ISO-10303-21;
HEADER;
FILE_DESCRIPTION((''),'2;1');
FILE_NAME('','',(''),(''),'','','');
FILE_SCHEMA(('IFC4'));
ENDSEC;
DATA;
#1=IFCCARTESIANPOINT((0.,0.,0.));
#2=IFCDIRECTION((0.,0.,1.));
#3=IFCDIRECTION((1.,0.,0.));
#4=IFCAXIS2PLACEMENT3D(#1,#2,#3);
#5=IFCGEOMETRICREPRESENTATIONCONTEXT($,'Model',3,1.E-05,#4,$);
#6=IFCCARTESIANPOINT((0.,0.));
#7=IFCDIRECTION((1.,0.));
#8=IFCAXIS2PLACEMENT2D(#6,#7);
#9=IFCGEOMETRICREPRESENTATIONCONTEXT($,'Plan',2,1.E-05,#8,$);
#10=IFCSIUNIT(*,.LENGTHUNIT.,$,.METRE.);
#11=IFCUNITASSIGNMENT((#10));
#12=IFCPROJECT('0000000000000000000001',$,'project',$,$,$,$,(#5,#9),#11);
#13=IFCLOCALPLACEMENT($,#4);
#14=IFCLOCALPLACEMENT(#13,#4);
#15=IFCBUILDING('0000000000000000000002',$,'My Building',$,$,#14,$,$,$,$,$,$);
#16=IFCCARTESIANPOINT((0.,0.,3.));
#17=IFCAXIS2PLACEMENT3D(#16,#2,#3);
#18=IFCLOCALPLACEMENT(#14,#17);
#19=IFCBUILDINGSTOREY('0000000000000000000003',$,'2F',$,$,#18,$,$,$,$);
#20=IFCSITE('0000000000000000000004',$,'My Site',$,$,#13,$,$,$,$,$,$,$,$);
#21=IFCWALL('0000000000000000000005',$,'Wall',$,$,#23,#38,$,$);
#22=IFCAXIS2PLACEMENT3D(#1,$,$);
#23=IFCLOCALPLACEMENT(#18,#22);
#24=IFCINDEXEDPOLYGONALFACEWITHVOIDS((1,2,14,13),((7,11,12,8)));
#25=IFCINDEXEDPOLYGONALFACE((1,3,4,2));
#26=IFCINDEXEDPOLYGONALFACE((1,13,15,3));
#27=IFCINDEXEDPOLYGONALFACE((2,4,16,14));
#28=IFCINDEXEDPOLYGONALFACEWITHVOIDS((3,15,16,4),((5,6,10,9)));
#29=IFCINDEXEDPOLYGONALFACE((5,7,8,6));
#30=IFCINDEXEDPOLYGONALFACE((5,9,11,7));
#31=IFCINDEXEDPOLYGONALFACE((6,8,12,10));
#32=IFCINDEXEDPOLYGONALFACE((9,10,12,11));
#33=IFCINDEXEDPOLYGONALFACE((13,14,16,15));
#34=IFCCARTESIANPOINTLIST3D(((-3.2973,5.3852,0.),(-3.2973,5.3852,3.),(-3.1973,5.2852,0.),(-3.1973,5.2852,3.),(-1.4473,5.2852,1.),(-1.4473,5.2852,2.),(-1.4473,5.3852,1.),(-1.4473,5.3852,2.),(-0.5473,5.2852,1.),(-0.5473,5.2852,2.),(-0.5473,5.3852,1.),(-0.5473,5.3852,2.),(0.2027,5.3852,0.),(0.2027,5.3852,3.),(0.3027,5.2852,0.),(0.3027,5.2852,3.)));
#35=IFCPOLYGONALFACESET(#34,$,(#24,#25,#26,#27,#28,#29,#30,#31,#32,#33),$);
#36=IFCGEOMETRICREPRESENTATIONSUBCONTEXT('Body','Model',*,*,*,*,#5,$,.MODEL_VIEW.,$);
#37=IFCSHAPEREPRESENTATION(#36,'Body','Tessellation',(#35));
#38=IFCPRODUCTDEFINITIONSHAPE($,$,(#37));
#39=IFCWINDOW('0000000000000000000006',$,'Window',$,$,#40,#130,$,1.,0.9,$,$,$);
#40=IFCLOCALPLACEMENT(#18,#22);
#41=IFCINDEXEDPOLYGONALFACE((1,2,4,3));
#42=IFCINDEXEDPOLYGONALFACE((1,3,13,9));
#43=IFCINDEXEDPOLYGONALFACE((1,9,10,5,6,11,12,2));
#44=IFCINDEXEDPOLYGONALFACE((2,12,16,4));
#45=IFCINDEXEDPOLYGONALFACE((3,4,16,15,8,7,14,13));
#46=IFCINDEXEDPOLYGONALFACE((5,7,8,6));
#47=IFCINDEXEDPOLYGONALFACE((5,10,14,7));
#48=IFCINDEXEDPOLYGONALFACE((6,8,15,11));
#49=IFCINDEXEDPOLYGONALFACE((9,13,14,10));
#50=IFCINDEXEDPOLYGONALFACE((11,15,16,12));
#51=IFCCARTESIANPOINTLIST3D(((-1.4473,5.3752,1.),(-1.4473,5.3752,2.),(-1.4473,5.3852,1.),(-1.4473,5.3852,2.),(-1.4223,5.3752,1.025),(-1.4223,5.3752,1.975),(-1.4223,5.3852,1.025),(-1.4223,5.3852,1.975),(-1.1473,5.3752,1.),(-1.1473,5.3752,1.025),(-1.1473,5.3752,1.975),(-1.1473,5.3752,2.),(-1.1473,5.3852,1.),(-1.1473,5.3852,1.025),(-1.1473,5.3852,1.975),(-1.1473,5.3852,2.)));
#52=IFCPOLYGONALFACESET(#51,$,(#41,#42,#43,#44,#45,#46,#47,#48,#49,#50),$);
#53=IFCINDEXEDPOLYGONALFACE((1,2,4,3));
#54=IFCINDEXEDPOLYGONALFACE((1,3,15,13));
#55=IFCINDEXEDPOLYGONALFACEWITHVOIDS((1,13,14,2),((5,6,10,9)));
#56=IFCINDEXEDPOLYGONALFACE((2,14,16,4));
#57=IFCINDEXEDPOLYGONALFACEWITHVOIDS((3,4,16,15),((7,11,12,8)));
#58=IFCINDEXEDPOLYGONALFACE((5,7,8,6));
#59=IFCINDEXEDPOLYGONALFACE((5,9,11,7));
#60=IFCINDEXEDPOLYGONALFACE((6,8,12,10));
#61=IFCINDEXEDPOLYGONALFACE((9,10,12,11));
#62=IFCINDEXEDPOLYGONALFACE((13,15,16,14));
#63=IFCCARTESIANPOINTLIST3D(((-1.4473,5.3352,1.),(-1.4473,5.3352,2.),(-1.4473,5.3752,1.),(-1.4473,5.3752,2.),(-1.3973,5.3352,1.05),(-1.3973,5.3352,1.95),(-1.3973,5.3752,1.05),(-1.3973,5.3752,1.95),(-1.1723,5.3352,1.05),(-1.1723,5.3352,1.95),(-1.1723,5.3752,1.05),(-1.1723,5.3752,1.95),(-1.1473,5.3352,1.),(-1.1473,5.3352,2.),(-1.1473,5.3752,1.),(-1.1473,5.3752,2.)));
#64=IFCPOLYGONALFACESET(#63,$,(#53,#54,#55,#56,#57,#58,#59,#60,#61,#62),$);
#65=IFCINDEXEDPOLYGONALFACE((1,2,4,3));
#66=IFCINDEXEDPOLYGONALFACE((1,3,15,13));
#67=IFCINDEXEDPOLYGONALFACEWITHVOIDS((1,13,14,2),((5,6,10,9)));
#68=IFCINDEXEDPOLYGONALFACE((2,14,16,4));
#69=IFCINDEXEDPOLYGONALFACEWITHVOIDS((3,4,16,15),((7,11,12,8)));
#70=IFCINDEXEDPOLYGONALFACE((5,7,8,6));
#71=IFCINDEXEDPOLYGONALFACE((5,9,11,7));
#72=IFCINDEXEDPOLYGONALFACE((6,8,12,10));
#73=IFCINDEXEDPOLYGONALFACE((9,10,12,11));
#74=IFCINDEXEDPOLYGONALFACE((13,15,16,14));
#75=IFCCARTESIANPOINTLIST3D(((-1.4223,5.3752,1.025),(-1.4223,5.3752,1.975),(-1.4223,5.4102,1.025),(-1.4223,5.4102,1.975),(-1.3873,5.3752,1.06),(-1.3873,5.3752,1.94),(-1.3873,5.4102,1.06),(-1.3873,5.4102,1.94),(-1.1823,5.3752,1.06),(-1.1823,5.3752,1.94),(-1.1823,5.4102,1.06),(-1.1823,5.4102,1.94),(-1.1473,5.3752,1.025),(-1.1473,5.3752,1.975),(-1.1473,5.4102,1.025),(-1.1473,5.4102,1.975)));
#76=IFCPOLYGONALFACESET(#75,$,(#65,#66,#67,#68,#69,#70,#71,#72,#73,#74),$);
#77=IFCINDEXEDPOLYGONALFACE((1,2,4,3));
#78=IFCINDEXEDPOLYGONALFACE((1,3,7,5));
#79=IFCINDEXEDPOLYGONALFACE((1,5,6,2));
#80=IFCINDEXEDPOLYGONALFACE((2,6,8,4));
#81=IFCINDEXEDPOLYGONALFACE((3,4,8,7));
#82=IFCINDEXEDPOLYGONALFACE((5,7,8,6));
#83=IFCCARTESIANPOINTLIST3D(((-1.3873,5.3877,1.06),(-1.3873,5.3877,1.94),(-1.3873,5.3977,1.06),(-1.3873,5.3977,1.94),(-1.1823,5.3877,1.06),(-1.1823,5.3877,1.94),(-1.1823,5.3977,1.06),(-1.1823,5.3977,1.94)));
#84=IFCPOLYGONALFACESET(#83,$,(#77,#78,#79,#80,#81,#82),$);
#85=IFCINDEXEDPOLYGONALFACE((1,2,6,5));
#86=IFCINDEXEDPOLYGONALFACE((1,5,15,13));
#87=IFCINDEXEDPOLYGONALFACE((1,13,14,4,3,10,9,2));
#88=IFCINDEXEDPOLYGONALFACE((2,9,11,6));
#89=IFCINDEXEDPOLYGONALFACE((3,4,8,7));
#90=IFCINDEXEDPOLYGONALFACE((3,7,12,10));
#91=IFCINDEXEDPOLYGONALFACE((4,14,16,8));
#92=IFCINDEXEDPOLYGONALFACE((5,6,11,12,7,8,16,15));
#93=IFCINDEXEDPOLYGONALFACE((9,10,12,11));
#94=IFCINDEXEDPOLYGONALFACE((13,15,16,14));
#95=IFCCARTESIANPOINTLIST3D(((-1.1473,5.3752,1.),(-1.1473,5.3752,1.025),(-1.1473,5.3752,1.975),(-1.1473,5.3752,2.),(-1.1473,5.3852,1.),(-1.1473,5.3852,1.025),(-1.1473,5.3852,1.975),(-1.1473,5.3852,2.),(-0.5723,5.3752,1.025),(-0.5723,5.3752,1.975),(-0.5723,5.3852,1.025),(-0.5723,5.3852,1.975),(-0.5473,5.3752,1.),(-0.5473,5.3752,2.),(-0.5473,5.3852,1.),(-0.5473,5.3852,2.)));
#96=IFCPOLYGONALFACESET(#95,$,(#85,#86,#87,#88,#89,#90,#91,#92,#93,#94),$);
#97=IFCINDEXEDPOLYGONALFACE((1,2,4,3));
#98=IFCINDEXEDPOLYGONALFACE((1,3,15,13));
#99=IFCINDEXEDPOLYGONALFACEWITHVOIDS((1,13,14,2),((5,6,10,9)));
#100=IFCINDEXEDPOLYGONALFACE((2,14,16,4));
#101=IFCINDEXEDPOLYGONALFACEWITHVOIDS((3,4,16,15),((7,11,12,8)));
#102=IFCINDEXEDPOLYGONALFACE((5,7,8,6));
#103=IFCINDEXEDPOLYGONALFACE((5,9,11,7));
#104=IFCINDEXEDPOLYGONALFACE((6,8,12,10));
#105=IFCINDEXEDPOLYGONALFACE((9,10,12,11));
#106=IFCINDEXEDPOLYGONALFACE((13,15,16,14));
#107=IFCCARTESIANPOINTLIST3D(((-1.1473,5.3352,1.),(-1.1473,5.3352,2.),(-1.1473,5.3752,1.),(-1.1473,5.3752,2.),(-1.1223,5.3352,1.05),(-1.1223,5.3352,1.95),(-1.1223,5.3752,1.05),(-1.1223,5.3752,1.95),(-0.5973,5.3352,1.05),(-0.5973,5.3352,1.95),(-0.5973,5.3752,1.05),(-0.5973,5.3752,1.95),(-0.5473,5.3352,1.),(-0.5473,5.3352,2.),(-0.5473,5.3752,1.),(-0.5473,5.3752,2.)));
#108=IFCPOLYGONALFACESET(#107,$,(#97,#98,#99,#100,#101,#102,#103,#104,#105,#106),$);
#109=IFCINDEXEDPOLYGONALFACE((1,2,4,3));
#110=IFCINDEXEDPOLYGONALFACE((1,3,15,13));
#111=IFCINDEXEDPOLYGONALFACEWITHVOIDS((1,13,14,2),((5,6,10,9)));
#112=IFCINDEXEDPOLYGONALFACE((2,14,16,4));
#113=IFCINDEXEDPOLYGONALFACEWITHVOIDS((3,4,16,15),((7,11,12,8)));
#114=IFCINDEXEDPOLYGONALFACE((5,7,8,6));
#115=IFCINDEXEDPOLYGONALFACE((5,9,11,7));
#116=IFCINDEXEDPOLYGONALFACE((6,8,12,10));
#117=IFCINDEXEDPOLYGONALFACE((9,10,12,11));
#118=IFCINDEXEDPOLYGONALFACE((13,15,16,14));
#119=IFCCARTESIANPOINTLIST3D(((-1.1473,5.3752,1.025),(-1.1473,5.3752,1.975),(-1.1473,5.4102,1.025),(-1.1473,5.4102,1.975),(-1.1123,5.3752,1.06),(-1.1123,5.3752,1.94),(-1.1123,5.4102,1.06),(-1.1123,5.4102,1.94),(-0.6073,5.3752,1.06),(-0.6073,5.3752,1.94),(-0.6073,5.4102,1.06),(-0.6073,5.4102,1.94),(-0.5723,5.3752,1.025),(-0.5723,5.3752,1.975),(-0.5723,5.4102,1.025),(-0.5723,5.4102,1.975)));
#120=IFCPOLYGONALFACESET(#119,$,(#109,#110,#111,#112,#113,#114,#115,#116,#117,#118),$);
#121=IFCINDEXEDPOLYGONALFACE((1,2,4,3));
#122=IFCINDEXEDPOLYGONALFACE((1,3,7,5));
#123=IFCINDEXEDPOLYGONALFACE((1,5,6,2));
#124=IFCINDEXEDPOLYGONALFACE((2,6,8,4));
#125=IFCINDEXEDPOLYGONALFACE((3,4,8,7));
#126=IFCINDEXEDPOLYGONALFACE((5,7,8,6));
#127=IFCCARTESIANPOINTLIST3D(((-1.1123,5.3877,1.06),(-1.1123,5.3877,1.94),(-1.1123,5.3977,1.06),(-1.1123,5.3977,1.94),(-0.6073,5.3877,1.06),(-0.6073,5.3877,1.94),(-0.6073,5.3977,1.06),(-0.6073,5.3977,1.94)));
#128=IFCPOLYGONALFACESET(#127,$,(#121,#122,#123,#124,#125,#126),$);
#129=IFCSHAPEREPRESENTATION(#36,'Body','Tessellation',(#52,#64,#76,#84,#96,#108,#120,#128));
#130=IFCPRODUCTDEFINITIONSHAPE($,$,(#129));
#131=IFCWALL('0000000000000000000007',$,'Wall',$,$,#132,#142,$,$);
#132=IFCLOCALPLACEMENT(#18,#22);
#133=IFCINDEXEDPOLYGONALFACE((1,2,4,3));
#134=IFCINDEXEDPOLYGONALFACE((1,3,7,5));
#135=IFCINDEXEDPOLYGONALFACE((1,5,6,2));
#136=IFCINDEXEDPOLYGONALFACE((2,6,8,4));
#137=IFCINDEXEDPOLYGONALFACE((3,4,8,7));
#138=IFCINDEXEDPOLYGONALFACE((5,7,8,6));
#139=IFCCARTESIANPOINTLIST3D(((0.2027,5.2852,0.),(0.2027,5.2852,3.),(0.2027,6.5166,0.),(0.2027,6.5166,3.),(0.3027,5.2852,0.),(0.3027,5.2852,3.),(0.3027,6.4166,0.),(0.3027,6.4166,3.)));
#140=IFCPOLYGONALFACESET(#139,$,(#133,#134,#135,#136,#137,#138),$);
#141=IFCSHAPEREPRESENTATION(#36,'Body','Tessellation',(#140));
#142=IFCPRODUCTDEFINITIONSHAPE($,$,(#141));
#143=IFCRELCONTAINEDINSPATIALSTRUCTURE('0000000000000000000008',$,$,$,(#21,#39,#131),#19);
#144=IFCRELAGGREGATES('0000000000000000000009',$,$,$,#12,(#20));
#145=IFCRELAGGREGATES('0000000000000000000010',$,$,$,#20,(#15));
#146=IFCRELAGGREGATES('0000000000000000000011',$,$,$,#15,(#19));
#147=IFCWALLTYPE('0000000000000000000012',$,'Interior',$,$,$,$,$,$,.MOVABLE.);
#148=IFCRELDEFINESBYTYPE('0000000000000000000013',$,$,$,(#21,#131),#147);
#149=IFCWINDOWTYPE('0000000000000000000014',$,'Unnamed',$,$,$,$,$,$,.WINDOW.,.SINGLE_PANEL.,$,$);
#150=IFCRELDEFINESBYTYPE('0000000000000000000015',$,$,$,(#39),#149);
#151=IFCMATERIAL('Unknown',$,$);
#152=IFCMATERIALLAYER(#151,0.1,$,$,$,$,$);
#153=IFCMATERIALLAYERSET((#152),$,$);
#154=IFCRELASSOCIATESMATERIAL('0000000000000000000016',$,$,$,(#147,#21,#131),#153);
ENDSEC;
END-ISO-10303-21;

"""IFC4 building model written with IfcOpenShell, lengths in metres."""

from ifc_helpers import new_model, entity, si_unit, frame, origin_with_axes, origin_2d_with_axis, place, context, subcontext, project, spatial, line, indexed_curve, outline, extrude, shape, source, transform, mapped, material, layer, layer_set, layer_usage, type_object, type_shapes, element, fill, save


model = new_model("IFC4")

# Units and contexts
model_context = context("Model", 3, precision=1e-05, world=origin_with_axes())
plan_context = context("Plan", 2, precision=1e-05, world=origin_2d_with_axis())
body_context_1 = subcontext(model_context, "Body", "Model", "MODEL_VIEW")
body_context_2 = subcontext(plan_context, "Body", "Plan", "PLAN_VIEW")
ifc_project = project(units=[si_unit("LENGTHUNIT", "METRE")], contexts=[model_context, plan_context])

# Site, building, storey
site_placement = place(None, origin_with_axes())
site = spatial("IfcSite", under=ifc_project, at=site_placement, Name="My Site")
building_placement = place(site_placement, origin_with_axes())
building = spatial("IfcBuilding", under=site, at=building_placement, Name="My Building")
storey_placement = place(building_placement, frame((0.0, 0.0, 3.0), z_axis=(0.0, 0.0, 1.0), x_axis=(1.0, 0.0, 0.0)))
storey = spatial("IfcBuildingStorey", under=building, at=storey_placement, Name="2F")

# Shared definitions
ifc_material = material(Name="Unknown")

# Wall, opening, window
ifc_layer_1 = layer(ifc_material, 0.1)
ifc_layer_set_1 = layer_set([ifc_layer_1])
ifc_layer_usage_1 = layer_usage(ifc_layer_set_1, "AXIS2", "POSITIVE", 0.0)
wall_type = type_object("IfcWallType", Name="Interior", PredefinedType="MOVABLE", material=ifc_layer_set_1)
wall_1_placement = place(storey_placement, frame((0.2027, 5.3852, 0.0), z_axis=(0.0, 0.0, 1.0), x_axis=(-1.0, 0.0, 0.0)))
wall_1 = element("IfcWall", 1, at=wall_1_placement, inside=storey, type_object=wall_type, material=ifc_layer_usage_1, Name="Wall", context=body_context_1, shape_type="SweptSolid", body=[
    extrude(outline(indexed_curve([(0.0, 0.0), (-0.1, 0.1), (3.4, 0.1), (3.5, 0.0)], segments=[line(1, 2, 3, 4, 1)])), origin_with_axes(), (0.0, 0.0, 1.0), 3.0),
])
shared_shape_1 = source(origin_with_axes(), body_context_1, "Body", "SweptSolid", [
    extrude(outline(indexed_curve([(0.0, 0.0), (0.9, 0.0), (0.9, 1.0), (0.0, 1.0)], segments=[line(1, 2, 3, 4, 1)])), frame((0.0, -0.6, 0.0), z_axis=(0.0, -1.0, 0.0), x_axis=(1.0, 0.0, 0.0)), (0.0, 0.0, -1.0), 1.2),
])
opening_1_placement = place(wall_1_placement, frame((1.65, 0.1, 1.0), z_axis=(0.0, 0.0, 1.0), x_axis=(-1.0, 0.0, 0.0)))
opening_1 = element("IfcOpeningElement", 2, at=opening_1_placement, cuts=wall_1, PredefinedType="OPENING", context=body_context_1, shape_type="MappedRepresentation", body=[
    mapped(shared_shape_1, transform((0.0, 0.0, 0.0), x_axis=(1.0, 0.0, 0.0), y_axis=(0.0, 1.0, 0.0), z_axis=(0.0, 0.0, 1.0), scale=1.0)),
])
window_type = type_object("IfcWindowType", Name="Unnamed", PartitioningType="SINGLE_PANEL", PredefinedType="WINDOW")
shared_shape_2 = source(origin_with_axes(), body_context_1, "Body", "SweptSolid", [
    extrude(outline(indexed_curve([(0.3, 0.0), (0.0, 0.0), (0.0, 1.0), (0.3, 1.0), (0.3, 0.975), (0.025, 0.975), (0.025, 0.025), (0.3, 0.025)], segments=[line(1, 2, 3, 4, 5, 6, 7, 8, 1)])), frame((0.0, 0.09, 0.0), z_axis=(0.0, -1.0, 0.0), x_axis=(1.0, 0.0, 0.0)), (0.0, 0.0, -1.0), 0.01),
    extrude(outline(indexed_curve([(0.0, 0.0), (0.3, 0.0), (0.3, 1.0), (0.0, 1.0)], segments=[line(1, 2, 3, 4, 1)]), holes=[indexed_curve([(0.05, 0.05), (0.275, 0.05), (0.275, 0.95), (0.05, 0.95)], segments=[line(1, 2, 3, 4, 1)])]), frame((0.0, 0.05, 0.0), z_axis=(0.0, -1.0, 0.0), x_axis=(1.0, 0.0, 0.0)), (0.0, 0.0, -1.0), 0.04),
    extrude(outline(indexed_curve([(0.0, 0.0), (0.275, 0.0), (0.275, 0.95), (0.0, 0.95)], segments=[line(1, 2, 3, 4, 1)]), holes=[indexed_curve([(0.035, 0.035), (0.24, 0.035), (0.24, 0.915), (0.035, 0.915)], segments=[line(1, 2, 3, 4, 1)])]), frame((0.025, 0.09, 0.025), z_axis=(0.0, -1.0, 0.0), x_axis=(1.0, 0.0, 0.0)), (0.0, 0.0, -1.0), 0.035),
    extrude(outline(indexed_curve([(0.035, 0.035), (0.24, 0.035), (0.24, 0.915), (0.035, 0.915)], segments=[line(1, 2, 3, 4, 1)])), frame((0.025, 0.1025, 0.025), z_axis=(0.0, -1.0, 0.0), x_axis=(1.0, 0.0, 0.0)), (0.0, 0.0, -1.0), 0.01),
    extrude(outline(indexed_curve([(0.0, 1.0), (0.6, 1.0), (0.6, 0.0), (0.0, 0.0), (0.0, 0.025), (0.575, 0.025), (0.575, 0.975), (0.0, 0.975)], segments=[line(1, 2, 3, 4, 5, 6, 7, 8, 1)])), frame((0.3, 0.09, 0.0), z_axis=(0.0, -1.0, 0.0), x_axis=(1.0, 0.0, 0.0)), (0.0, 0.0, -1.0), 0.01),
    extrude(outline(indexed_curve([(0.0, 0.0), (0.6, 0.0), (0.6, 1.0), (0.0, 1.0)], segments=[line(1, 2, 3, 4, 1)]), holes=[indexed_curve([(0.025, 0.05), (0.55, 0.05), (0.55, 0.95), (0.025, 0.95)], segments=[line(1, 2, 3, 4, 1)])]), frame((0.3, 0.05, 0.0), z_axis=(0.0, -1.0, 0.0), x_axis=(1.0, 0.0, 0.0)), (0.0, 0.0, -1.0), 0.04),
    extrude(outline(indexed_curve([(0.0, 0.0), (0.575, 0.0), (0.575, 0.95), (0.0, 0.95)], segments=[line(1, 2, 3, 4, 1)]), holes=[indexed_curve([(0.035, 0.035), (0.54, 0.035), (0.54, 0.915), (0.035, 0.915)], segments=[line(1, 2, 3, 4, 1)])]), frame((0.3, 0.09, 0.025), z_axis=(0.0, -1.0, 0.0), x_axis=(1.0, 0.0, 0.0)), (0.0, 0.0, -1.0), 0.035),
    extrude(outline(indexed_curve([(0.035, 0.035), (0.54, 0.035), (0.54, 0.915), (0.035, 0.915)], segments=[line(1, 2, 3, 4, 1)])), frame((0.3, 0.1025, 0.025), z_axis=(0.0, -1.0, 0.0), x_axis=(1.0, 0.0, 0.0)), (0.0, 0.0, -1.0), 0.01),
])
shared_shape_3 = source(origin_with_axes(), body_context_2, "Body", "Curve2D", [
    entity("IfcIndexedPolyCurve", entity("IfcCartesianPointList2D", [[0.05, 0.05], [0.275, 0.05]])),
    entity("IfcIndexedPolyCurve", entity("IfcCartesianPointList2D", [[0.0, 0.1], [0.025, 0.1], [0.025, 0.09], [0.05, 0.09], [0.05, 0.05], [0.0, 0.05]]), [entity("IfcLineIndex", [1, 2, 3, 4, 5, 6, 1])]),
    entity("IfcIndexedPolyCurve", entity("IfcCartesianPointList2D", [[0.3, 0.1], [0.3, 0.1], [0.3, 0.09], [0.275, 0.09], [0.275, 0.05], [0.3, 0.05]])),
    entity("IfcIndexedPolyCurve", entity("IfcCartesianPointList2D", [[0.025, 0.09], [0.06, 0.09], [0.06, 0.125], [0.025, 0.125]]), [entity("IfcLineIndex", [1, 2, 3, 4, 1])]),
    entity("IfcIndexedPolyCurve", entity("IfcCartesianPointList2D", [[0.3, 0.09], [0.265, 0.09], [0.265, 0.125], [0.3, 0.125]]), [entity("IfcLineIndex", [1, 2, 3, 4, 1])]),
    entity("IfcIndexedPolyCurve", entity("IfcCartesianPointList2D", [[0.06, 0.09], [0.265, 0.09]])),
    entity("IfcIndexedPolyCurve", entity("IfcCartesianPointList2D", [[0.06, 0.125], [0.265, 0.125]])),
    entity("IfcIndexedPolyCurve", entity("IfcCartesianPointList2D", [[0.06, 0.1075], [0.265, 0.1075]])),
    entity("IfcIndexedPolyCurve", entity("IfcCartesianPointList2D", [[0.325, 0.05], [0.85, 0.05]])),
    entity("IfcIndexedPolyCurve", entity("IfcCartesianPointList2D", [[0.3, 0.1], [0.3, 0.1], [0.3, 0.09], [0.325, 0.09], [0.325, 0.05], [0.3, 0.05]])),
    entity("IfcIndexedPolyCurve", entity("IfcCartesianPointList2D", [[0.9, 0.1], [0.875, 0.1], [0.875, 0.09], [0.85, 0.09], [0.85, 0.05], [0.9, 0.05]]), [entity("IfcLineIndex", [1, 2, 3, 4, 5, 6, 1])]),
    entity("IfcIndexedPolyCurve", entity("IfcCartesianPointList2D", [[0.3, 0.09], [0.335, 0.09], [0.335, 0.125], [0.3, 0.125]]), [entity("IfcLineIndex", [1, 2, 3, 4, 1])]),
    entity("IfcIndexedPolyCurve", entity("IfcCartesianPointList2D", [[0.875, 0.09], [0.84, 0.09], [0.84, 0.125], [0.875, 0.125]]), [entity("IfcLineIndex", [1, 2, 3, 4, 1])]),
    entity("IfcIndexedPolyCurve", entity("IfcCartesianPointList2D", [[0.335, 0.09], [0.84, 0.09]])),
    entity("IfcIndexedPolyCurve", entity("IfcCartesianPointList2D", [[0.335, 0.125], [0.84, 0.125]])),
    entity("IfcIndexedPolyCurve", entity("IfcCartesianPointList2D", [[0.335, 0.1075], [0.84, 0.1075]])),
])
type_shapes(window_type, [shared_shape_2, shared_shape_3])
window_1_placement = place(opening_1_placement, frame((0.0, 0.0, 0.0), z_axis=(0.0, 0.0, 1.0), x_axis=(1.0, 0.0, 0.0)))
window_1 = element("IfcWindow", 3, at=window_1_placement, inside=storey, type_object=window_type, Name="Window", OverallHeight=1.0, OverallWidth=0.9, shapes=[
    shape(body_context_1, "Body", "MappedRepresentation", [mapped(shared_shape_2, transform((0.0, 0.0, 0.0), x_axis=(1.0, 0.0, 0.0), y_axis=(0.0, 1.0, 0.0), z_axis=(0.0, 0.0, 1.0), scale=1.0))]),
    shape(body_context_2, "Body", "MappedRepresentation", [mapped(shared_shape_3, transform((0.0, 0.0, 0.0), x_axis=(1.0, 0.0, 0.0), y_axis=(0.0, 1.0, 0.0), z_axis=(0.0, 0.0, 1.0), scale=1.0))]),
])
fill(opening_1, window_1)

# Wall
ifc_layer_usage_2 = layer_usage(ifc_layer_set_1, "AXIS2", "POSITIVE", 0.0)
wall_2_placement = place(storey_placement, frame((0.3027, 5.2852, 0.0), z_axis=(0.0, 0.0, 1.0), x_axis=(0.0, 1.0, 0.0)))
element("IfcWall", 4, at=wall_2_placement, inside=storey, type_object=wall_type, material=ifc_layer_usage_2, Name="Wall", context=body_context_1, shape_type="SweptSolid", body=[
    extrude(outline(indexed_curve([(0.0, 0.0), (0.0, 0.1), (1.2314, 0.1), (1.1314, 0.0)], segments=[line(1, 2, 3, 4, 1)])), origin_with_axes(), (0.0, 0.0, 1.0), 3.0),
])

save(model, "model.ifc")
